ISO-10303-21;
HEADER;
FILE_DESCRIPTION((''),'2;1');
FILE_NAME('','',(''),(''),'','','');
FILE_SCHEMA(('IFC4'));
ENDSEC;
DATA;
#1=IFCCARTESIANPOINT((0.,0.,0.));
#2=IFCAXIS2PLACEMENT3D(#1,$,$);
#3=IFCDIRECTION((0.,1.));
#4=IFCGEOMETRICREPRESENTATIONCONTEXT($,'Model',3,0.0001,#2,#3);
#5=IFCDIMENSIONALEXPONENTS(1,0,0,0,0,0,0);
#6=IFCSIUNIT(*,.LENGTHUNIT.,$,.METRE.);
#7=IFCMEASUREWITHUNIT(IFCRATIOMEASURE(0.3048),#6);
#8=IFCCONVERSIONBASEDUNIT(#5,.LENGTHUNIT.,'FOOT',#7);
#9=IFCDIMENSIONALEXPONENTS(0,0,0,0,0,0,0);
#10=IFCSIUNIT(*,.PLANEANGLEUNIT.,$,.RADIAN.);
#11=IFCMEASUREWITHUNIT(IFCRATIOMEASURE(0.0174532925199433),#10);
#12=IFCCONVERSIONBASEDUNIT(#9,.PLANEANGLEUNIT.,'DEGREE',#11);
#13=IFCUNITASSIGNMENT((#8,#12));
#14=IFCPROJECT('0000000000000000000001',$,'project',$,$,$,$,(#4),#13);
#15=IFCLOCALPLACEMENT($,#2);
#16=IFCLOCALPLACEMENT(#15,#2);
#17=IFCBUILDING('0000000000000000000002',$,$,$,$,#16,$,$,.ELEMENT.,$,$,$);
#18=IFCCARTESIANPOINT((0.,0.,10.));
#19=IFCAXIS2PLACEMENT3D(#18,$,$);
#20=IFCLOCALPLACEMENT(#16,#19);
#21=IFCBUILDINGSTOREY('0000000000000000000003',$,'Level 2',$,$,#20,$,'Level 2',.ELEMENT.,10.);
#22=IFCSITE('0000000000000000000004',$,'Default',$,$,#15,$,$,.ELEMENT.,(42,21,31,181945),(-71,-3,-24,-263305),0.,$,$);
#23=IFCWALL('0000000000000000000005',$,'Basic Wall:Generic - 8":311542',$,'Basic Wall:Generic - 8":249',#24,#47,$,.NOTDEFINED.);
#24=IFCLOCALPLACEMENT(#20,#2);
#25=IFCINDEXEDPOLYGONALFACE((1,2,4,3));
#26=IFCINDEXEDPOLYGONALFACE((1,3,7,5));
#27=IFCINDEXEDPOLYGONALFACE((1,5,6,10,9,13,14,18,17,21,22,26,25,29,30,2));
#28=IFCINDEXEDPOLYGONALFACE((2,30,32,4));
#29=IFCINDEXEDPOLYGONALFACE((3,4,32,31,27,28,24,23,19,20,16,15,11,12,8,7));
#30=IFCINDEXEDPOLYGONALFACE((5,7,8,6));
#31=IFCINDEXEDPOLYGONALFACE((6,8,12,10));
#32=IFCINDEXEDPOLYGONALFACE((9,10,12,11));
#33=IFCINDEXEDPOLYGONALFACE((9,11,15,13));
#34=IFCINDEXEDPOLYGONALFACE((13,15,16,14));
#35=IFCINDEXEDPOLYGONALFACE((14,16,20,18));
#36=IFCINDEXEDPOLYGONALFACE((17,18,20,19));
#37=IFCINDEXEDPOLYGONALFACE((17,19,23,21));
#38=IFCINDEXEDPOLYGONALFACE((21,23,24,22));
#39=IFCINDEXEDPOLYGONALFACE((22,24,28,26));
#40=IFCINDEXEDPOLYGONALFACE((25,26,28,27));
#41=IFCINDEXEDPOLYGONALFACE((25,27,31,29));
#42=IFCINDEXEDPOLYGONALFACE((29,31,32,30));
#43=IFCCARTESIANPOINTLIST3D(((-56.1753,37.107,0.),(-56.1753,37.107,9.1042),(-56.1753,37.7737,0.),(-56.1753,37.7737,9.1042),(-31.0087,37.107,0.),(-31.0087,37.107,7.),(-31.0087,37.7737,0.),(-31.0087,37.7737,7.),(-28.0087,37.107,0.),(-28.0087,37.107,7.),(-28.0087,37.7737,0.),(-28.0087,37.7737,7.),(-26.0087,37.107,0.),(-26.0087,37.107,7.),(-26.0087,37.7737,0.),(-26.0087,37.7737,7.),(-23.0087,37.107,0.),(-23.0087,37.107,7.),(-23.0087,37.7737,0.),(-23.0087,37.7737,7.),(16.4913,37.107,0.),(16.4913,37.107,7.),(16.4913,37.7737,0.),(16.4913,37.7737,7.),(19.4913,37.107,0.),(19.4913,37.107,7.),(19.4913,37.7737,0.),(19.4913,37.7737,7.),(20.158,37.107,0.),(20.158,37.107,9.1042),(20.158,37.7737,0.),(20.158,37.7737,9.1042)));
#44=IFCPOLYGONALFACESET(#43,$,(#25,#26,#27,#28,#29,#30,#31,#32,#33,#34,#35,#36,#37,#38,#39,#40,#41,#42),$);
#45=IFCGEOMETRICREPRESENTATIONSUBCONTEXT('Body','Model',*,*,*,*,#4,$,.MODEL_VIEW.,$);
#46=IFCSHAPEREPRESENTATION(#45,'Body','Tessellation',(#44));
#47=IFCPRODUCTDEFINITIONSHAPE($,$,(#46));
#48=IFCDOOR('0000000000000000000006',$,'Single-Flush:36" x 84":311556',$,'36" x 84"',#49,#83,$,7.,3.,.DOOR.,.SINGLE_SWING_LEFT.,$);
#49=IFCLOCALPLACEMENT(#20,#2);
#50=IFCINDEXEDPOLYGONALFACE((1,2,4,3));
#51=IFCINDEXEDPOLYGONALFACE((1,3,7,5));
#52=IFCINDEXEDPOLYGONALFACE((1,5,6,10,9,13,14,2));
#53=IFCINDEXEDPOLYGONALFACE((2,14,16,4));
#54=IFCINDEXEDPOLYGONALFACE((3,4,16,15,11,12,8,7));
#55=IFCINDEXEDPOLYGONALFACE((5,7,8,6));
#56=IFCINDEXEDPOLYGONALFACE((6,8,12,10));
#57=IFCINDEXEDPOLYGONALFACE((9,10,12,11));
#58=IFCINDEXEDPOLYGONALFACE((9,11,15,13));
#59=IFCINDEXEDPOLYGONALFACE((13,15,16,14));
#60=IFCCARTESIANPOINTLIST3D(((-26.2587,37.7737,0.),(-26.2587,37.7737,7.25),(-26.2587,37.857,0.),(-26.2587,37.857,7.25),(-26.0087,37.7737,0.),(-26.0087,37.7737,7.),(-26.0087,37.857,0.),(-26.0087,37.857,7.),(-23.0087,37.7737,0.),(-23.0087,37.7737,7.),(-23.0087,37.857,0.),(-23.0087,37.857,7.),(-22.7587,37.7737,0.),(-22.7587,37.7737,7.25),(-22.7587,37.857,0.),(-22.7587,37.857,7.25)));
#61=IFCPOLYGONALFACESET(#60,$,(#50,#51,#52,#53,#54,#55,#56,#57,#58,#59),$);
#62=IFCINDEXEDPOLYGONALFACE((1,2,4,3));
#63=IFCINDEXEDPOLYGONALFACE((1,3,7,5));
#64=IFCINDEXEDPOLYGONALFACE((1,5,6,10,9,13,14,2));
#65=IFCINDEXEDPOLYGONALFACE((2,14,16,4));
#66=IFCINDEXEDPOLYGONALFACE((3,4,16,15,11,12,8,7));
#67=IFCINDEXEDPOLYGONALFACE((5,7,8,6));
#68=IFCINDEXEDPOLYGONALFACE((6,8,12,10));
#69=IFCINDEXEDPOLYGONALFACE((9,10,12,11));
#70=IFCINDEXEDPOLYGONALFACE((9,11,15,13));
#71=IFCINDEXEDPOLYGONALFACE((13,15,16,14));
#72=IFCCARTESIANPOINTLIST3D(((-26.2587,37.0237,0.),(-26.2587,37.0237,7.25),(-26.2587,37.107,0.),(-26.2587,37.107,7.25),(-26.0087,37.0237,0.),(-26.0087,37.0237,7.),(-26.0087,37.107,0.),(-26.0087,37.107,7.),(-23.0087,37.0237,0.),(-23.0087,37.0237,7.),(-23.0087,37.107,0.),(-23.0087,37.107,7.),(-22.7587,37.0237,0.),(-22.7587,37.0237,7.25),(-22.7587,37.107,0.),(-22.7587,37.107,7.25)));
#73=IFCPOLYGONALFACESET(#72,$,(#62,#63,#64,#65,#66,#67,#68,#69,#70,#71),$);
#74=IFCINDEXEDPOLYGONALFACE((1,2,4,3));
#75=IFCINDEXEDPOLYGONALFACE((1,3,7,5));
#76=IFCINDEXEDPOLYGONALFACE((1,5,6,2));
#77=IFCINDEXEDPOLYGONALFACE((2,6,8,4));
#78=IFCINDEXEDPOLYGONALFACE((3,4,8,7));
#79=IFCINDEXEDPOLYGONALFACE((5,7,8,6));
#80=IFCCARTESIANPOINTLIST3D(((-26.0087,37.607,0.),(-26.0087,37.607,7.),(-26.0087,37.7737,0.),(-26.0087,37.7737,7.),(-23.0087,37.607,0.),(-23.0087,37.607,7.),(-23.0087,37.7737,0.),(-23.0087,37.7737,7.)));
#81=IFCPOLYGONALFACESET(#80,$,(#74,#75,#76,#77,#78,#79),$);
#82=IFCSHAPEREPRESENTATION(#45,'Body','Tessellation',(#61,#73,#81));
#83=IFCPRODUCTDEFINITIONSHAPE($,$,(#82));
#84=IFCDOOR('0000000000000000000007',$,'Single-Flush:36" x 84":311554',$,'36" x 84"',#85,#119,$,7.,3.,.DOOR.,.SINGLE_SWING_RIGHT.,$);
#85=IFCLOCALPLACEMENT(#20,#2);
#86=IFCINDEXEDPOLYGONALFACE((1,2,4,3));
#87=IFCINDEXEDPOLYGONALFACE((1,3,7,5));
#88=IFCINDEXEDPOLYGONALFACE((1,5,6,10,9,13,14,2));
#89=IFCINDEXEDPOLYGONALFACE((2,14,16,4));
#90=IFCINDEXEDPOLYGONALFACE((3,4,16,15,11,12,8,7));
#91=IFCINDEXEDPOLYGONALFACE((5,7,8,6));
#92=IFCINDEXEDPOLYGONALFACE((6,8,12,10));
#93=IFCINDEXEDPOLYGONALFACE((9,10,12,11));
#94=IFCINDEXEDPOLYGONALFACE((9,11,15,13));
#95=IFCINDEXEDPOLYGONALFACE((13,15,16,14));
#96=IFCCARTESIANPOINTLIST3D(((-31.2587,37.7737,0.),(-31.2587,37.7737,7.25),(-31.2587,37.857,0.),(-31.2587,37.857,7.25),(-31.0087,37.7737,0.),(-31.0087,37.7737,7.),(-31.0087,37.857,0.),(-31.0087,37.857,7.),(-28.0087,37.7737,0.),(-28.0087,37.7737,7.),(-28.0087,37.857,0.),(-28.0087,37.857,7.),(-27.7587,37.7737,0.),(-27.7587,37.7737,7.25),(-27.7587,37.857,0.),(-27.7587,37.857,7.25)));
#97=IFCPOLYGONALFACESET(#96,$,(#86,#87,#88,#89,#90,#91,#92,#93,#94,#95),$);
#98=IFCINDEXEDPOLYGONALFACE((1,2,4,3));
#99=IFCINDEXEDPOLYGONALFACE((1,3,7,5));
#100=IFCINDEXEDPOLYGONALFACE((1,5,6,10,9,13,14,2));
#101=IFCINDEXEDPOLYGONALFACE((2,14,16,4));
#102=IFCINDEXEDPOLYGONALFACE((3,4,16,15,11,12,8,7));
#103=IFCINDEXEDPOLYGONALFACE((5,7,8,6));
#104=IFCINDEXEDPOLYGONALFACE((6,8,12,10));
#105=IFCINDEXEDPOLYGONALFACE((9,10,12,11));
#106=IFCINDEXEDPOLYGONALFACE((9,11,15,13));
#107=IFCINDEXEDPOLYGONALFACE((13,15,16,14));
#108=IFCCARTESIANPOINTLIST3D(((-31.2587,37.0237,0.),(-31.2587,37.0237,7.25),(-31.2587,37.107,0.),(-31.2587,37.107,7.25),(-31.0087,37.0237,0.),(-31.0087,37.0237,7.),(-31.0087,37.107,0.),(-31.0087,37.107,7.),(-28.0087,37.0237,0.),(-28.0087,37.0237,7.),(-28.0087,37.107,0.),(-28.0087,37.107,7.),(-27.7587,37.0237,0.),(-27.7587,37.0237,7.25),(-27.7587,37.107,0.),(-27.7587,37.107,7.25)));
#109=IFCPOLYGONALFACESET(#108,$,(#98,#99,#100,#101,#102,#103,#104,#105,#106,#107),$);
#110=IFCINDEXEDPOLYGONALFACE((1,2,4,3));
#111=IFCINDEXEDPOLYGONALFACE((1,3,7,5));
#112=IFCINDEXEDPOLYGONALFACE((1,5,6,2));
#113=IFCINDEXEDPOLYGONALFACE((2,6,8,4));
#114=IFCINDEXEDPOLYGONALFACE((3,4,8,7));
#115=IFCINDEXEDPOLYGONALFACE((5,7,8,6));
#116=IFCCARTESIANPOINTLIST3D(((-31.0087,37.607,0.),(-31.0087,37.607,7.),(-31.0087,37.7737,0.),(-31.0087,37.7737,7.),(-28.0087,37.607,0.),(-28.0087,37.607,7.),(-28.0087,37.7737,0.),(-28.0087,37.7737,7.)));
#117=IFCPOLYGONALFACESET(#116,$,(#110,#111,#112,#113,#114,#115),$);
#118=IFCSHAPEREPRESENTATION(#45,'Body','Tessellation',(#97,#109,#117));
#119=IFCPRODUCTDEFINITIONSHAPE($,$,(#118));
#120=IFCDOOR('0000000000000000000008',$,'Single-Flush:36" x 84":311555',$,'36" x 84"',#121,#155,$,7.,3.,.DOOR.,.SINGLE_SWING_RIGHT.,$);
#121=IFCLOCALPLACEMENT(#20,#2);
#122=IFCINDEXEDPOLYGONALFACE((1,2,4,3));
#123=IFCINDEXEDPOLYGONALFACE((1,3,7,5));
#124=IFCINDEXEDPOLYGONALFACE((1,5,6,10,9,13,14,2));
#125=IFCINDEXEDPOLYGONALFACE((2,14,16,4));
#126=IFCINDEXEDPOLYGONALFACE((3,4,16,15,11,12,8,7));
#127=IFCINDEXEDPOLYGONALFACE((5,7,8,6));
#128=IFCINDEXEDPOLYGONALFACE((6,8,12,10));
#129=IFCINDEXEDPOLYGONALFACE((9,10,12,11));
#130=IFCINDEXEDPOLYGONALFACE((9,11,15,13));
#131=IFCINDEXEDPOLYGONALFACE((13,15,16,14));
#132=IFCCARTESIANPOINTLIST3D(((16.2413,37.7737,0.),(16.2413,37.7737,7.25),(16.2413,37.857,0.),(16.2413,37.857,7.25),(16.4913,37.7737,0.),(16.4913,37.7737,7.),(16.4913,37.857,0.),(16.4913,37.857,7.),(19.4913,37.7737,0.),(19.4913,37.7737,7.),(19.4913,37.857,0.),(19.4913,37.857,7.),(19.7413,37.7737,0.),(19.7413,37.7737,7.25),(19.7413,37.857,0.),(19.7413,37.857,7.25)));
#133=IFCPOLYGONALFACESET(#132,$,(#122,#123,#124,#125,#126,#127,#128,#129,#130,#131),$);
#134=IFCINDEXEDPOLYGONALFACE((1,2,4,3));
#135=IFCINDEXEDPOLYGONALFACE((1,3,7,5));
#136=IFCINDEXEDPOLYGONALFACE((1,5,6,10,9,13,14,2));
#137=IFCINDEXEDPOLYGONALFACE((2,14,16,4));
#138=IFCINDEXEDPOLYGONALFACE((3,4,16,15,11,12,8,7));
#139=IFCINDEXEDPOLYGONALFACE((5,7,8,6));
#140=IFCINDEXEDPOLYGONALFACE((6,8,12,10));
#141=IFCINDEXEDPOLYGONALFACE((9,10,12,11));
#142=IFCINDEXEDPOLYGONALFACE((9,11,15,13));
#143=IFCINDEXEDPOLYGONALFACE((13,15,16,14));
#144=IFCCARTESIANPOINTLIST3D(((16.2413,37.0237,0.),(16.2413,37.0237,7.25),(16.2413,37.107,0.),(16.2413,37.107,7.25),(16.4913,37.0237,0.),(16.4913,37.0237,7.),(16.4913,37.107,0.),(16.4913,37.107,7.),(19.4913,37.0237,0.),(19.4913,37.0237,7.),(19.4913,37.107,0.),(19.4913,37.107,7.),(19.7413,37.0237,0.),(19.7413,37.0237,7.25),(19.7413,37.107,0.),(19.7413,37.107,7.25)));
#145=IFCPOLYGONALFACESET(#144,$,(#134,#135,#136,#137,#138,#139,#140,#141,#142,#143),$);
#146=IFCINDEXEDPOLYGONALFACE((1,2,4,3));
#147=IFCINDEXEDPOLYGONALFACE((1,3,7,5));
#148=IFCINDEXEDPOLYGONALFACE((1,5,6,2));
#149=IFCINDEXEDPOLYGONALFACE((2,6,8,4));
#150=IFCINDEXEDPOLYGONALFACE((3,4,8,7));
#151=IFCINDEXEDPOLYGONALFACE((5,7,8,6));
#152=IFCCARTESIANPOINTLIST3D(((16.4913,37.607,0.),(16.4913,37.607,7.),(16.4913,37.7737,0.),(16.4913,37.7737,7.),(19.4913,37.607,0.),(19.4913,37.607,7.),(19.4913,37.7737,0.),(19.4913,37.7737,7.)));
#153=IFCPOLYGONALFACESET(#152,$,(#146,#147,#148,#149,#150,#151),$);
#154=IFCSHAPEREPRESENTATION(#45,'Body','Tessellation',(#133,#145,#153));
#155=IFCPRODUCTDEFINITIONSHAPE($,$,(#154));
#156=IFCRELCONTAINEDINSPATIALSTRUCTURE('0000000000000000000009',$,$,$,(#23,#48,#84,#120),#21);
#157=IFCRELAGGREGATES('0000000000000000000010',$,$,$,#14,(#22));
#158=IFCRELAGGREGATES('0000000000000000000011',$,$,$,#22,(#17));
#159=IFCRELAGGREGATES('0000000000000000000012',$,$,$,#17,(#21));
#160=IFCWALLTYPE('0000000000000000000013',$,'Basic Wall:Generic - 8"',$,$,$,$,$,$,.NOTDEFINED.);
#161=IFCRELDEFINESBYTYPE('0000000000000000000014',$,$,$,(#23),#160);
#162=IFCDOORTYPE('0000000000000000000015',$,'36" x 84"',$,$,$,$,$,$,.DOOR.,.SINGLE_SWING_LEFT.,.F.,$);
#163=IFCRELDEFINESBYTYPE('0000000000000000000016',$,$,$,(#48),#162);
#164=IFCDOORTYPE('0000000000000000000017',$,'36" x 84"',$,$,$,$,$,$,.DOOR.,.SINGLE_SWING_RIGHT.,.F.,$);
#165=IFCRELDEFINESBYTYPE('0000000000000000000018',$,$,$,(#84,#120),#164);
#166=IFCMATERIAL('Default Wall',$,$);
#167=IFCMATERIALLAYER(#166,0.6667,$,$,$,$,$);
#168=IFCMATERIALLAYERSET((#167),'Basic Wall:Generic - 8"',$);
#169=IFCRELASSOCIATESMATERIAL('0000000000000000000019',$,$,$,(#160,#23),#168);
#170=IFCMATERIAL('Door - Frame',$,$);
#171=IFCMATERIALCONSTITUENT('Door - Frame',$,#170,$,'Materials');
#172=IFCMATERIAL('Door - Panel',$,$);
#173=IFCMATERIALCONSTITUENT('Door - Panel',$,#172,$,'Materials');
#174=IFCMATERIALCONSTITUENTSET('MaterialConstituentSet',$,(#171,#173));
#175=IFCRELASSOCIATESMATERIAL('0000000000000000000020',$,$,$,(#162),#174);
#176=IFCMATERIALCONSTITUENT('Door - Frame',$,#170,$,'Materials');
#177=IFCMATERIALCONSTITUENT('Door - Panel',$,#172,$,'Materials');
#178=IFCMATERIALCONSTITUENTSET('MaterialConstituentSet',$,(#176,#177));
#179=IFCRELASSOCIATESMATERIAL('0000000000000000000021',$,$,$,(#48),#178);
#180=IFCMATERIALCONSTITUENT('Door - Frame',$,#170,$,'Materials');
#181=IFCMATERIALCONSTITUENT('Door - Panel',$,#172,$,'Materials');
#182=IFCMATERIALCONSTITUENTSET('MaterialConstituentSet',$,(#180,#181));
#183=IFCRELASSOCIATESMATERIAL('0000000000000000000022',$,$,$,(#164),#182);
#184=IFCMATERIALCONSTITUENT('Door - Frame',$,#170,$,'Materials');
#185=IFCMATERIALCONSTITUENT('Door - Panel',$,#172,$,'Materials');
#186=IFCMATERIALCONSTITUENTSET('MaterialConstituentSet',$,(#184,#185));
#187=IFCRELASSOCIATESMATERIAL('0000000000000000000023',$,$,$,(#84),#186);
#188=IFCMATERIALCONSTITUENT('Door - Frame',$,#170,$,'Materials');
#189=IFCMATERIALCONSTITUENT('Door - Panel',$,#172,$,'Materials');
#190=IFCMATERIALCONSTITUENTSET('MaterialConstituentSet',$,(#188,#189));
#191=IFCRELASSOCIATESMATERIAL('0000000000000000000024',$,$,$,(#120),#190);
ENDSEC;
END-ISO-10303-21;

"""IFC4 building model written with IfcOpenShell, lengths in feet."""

from ifc_helpers import new_model, entity, si_unit, converted_unit, direction, frame, frame_2d, origin, place, context, subcontext, project, spatial, polyline, rectangle, outline, extrude, clip, bounded_halfspace, source, transform, mapped, material, layer, layer_set, layer_usage, constituent, constituent_set, type_object, type_shapes, element, fill, save


model = new_model("IFC4")

# Units and contexts
model_context = context("Model", 3, precision=0.0001, world=origin(), true_north=direction((0.0, 1.0)))
body_context = subcontext(model_context, "Body", "Model", "MODEL_VIEW")
ifc_project = project(units=[converted_unit("LENGTHUNIT", "FOOT", entity("IfcRatioMeasure", 0.3048), si_unit("LENGTHUNIT", "METRE"), dimensions=[1, 0, 0, 0, 0, 0, 0]), converted_unit("PLANEANGLEUNIT", "DEGREE", entity("IfcRatioMeasure", 0.0174532925199433), si_unit("PLANEANGLEUNIT", "RADIAN"), dimensions=[0, 0, 0, 0, 0, 0, 0])], contexts=[model_context])

# Site, building, storey
site_placement = place(None, origin())
site = spatial("IfcSite", under=ifc_project, at=site_placement, Name="Default", CompositionType="ELEMENT", RefLatitude=(42, 21, 31, 181945), RefLongitude=(-71, -3, -24, -263305), RefElevation=0.0)
building_placement = place(site_placement, origin())
building = spatial("IfcBuilding", under=site, at=building_placement, CompositionType="ELEMENT")
storey_placement = place(building_placement, frame((0.0, 0.0, 10.0)))
storey = spatial("IfcBuildingStorey", under=building, at=storey_placement, Name="Level 2", LongName="Level 2", CompositionType="ELEMENT", Elevation=10.0)

# Shared definitions
ifc_material_1 = material(Name="Default Wall")
ifc_layer = layer(ifc_material_1, 0.6667)
ifc_layer_set = layer_set([ifc_layer], Name="Basic Wall:Generic - 8\"")
wall_type = type_object("IfcWallType", Name="Basic Wall:Generic - 8\"", PredefinedType="NOTDEFINED", material=ifc_layer_set)

# Wall, openings, doors
ifc_layer_usage_1 = layer_usage(ifc_layer_set, "AXIS2", "NEGATIVE", 0.3333)
wall_1_placement = place(storey_placement, frame((-56.1753, 37.4404, 0.0)))
wall_1 = element("IfcWall", 1, at=wall_1_placement, inside=storey, type_object=wall_type, material=ifc_layer_usage_1, Name="Basic Wall:Generic - 8\":311542", ObjectType="Basic Wall:Generic - 8\":249", PredefinedType="NOTDEFINED", context=body_context, shape_type="Clipping", body=[
    clip(extrude(rectangle(XDim=76.3333, YDim=0.6667, at=frame_2d((38.1667, 0.0), x_axis=(-1.0, 0.0))), origin(), (0.0, 0.0, 1.0), 9.1042), bounded_halfspace(frame((0.0, -0.3333, 9.1042), z_axis=(0.0, 0.0, -1.0), x_axis=(0.0, -1.0, 0.0)), True, frame((0.0, -0.3333, 9.1042), z_axis=(0.0, 0.0, -1.0), x_axis=(0.0, -1.0, 0.0)), polyline([(0.0, 0.0), (-0.6667, 0.0), (-0.6667, -28.8333), (-0.6667, -29.5), (-0.6667, -51.8333), (-0.6667, -52.5), (-0.6667, -76.3333), (0.0, -76.3333), (0.0, -20.5), (0.0, -19.8333), (0.0, 0.0)]))),
])
opening_1_placement = place(wall_1_placement, frame((25.1667, -0.3333, 0.0)))
opening_1 = element("IfcOpeningElement", 2, at=opening_1_placement, cuts=wall_1, ObjectType="Opening", PredefinedType="OPENING", context=body_context, shape_type="SweptSolid", body=[
    extrude(rectangle(XDim=3.0, YDim=7.0, at=frame_2d((3.5, 1.5), x_axis=(0.0, 1.0))), frame((0.0, 0.0, 0.0), z_axis=(0.0, 1.0, 0.0), x_axis=(0.0, 0.0, 1.0)), (0.0, 0.0, 1.0), 0.6667),
])
opening_2_placement = place(wall_1_placement, frame((72.6667, -0.3333, 0.0)))
opening_2 = element("IfcOpeningElement", 3, at=opening_2_placement, cuts=wall_1, ObjectType="Opening", PredefinedType="OPENING", context=body_context, shape_type="SweptSolid", body=[
    extrude(rectangle(XDim=3.0, YDim=7.0, at=frame_2d((3.5, 1.5), x_axis=(0.0, 1.0))), frame((0.0, 0.0, 0.0), z_axis=(0.0, 1.0, 0.0), x_axis=(0.0, 0.0, 1.0)), (0.0, 0.0, 1.0), 0.6667),
])
opening_3_placement = place(wall_1_placement, frame((30.1667, -0.3333, 0.0)))
opening_3 = element("IfcOpeningElement", 4, at=opening_3_placement, cuts=wall_1, ObjectType="Opening", PredefinedType="OPENING", context=body_context, shape_type="SweptSolid", body=[
    extrude(rectangle(XDim=3.0, YDim=7.0, at=frame_2d((3.5, 1.5), x_axis=(0.0, -1.0))), frame((0.0, 0.0, 0.0), z_axis=(0.0, 1.0, 0.0), x_axis=(0.0, 0.0, 1.0)), (0.0, 0.0, 1.0), 0.6667),
])
ifc_material_2 = material(Name="Door - Frame")
ifc_constituent_1 = constituent(ifc_material_2, Name="Door - Frame", Category="Materials")
ifc_material_3 = material(Name="Door - Panel")
ifc_constituent_2 = constituent(ifc_material_3, Name="Door - Panel", Category="Materials")
ifc_constituent_set_1 = constituent_set(constituents=[ifc_constituent_1, ifc_constituent_2], Name="MaterialConstituentSet")
ifc_constituent_3 = constituent(ifc_material_2, Name="Door - Frame", Category="Materials")
ifc_constituent_4 = constituent(ifc_material_3, Name="Door - Panel", Category="Materials")
ifc_constituent_set_2 = constituent_set(constituents=[ifc_constituent_3, ifc_constituent_4], Name="MaterialConstituentSet")
door_type_1 = type_object("IfcDoorType", Name="36\" x 84\"", OperationType="SINGLE_SWING_LEFT", ParameterTakesPrecedence=False, PredefinedType="DOOR", material=ifc_constituent_set_2)
shared_shape_1 = source(origin(), body_context, "Body", "SweptSolid", [
    extrude(outline(polyline([(-1.75, -3.6875), (1.75, -3.6875), (1.75, 3.5625), (1.5, 3.5625), (1.5, -3.4375), (-1.5, -3.4375), (-1.5, 3.5625), (-1.75, 3.5625), (-1.75, -3.6875)])), frame((1.5, 0.75, 3.5625), z_axis=(0.0, -1.0, 0.0), x_axis=(-1.0, 0.0, 0.0)), (0.0, 0.0, 1.0), 0.0833),
    extrude(outline(polyline([(-3.6875, -1.75), (3.5625, -1.75), (3.5625, -1.5), (-3.4375, -1.5), (-3.4375, 1.5), (3.5625, 1.5), (3.5625, 1.75), (-3.6875, 1.75), (-3.6875, -1.75)])), frame((1.5, 0.0, 3.5625), z_axis=(0.0, -1.0, 0.0), x_axis=(0.0, 0.0, -1.0)), (0.0, 0.0, 1.0), 0.0833),
    extrude(rectangle(XDim=3.0, YDim=0.1667, at=frame_2d((0.0, 0.0), x_axis=(1.0, 0.0))), frame((1.5, 0.5833, 0.0)), (0.0, 0.0, 1.0), 7.0),
])
type_shapes(door_type_1, [shared_shape_1])
door_1_placement = place(opening_3_placement, origin())
door_1 = element("IfcDoor", 5, at=door_1_placement, inside=storey, type_object=door_type_1, material=ifc_constituent_set_1, Name="Single-Flush:36\" x 84\":311556", ObjectType="36\" x 84\"", OperationType="SINGLE_SWING_LEFT", OverallHeight=7.0, OverallWidth=3.0, PredefinedType="DOOR", context=body_context, shape_type="MappedRepresentation", body=[
    mapped(shared_shape_1, transform((0.0, 0.0, 0.0), scale=1.0)),
])
fill(opening_3, door_1)
ifc_constituent_5 = constituent(ifc_material_2, Name="Door - Frame", Category="Materials")
ifc_constituent_6 = constituent(ifc_material_3, Name="Door - Panel", Category="Materials")
ifc_constituent_set_3 = constituent_set(constituents=[ifc_constituent_5, ifc_constituent_6], Name="MaterialConstituentSet")
ifc_constituent_7 = constituent(ifc_material_2, Name="Door - Frame", Category="Materials")
ifc_constituent_8 = constituent(ifc_material_3, Name="Door - Panel", Category="Materials")
ifc_constituent_set_4 = constituent_set(constituents=[ifc_constituent_7, ifc_constituent_8], Name="MaterialConstituentSet")
door_type_2 = type_object("IfcDoorType", Name="36\" x 84\"", OperationType="SINGLE_SWING_RIGHT", ParameterTakesPrecedence=False, PredefinedType="DOOR", material=ifc_constituent_set_4)
shared_shape_2 = source(origin(), body_context, "Body", "SweptSolid", [
    extrude(outline(polyline([(-1.75, -3.6875), (1.75, -3.6875), (1.75, 3.5625), (1.5, 3.5625), (1.5, -3.4375), (-1.5, -3.4375), (-1.5, 3.5625), (-1.75, 3.5625), (-1.75, -3.6875)])), frame((1.5, 0.6667, 3.5625), z_axis=(0.0, 1.0, 0.0), x_axis=(1.0, 0.0, 0.0)), (0.0, 0.0, 1.0), 0.0833),
    extrude(outline(polyline([(-3.6875, -1.75), (3.5625, -1.75), (3.5625, -1.5), (-3.4375, -1.5), (-3.4375, 1.5), (3.5625, 1.5), (3.5625, 1.75), (-3.6875, 1.75), (-3.6875, -1.75)])), frame((1.5, -0.0833, 3.5625), z_axis=(0.0, 1.0, 0.0), x_axis=(0.0, 0.0, -1.0)), (0.0, 0.0, 1.0), 0.0833),
    extrude(rectangle(XDim=0.1667, YDim=3.0, at=frame_2d((0.0, 0.0), x_axis=(1.0, 0.0))), frame((1.5, 0.5833, 0.0), z_axis=(0.0, 0.0, 1.0), x_axis=(0.0, 1.0, 0.0)), (0.0, 0.0, 1.0), 7.0),
])
type_shapes(door_type_2, [shared_shape_2])
door_2_placement = place(opening_1_placement, origin())
door_2 = element("IfcDoor", 6, at=door_2_placement, inside=storey, type_object=door_type_2, material=ifc_constituent_set_3, Name="Single-Flush:36\" x 84\":311554", ObjectType="36\" x 84\"", OperationType="SINGLE_SWING_RIGHT", OverallHeight=7.0, OverallWidth=3.0, PredefinedType="DOOR", context=body_context, shape_type="MappedRepresentation", body=[
    mapped(shared_shape_2, transform((0.0, 0.0, 0.0), scale=1.0)),
])
fill(opening_1, door_2)
ifc_constituent_9 = constituent(ifc_material_2, Name="Door - Frame", Category="Materials")
ifc_constituent_10 = constituent(ifc_material_3, Name="Door - Panel", Category="Materials")
ifc_constituent_set_5 = constituent_set(constituents=[ifc_constituent_9, ifc_constituent_10], Name="MaterialConstituentSet")
door_3_placement = place(opening_2_placement, origin())
door_3 = element("IfcDoor", 7, at=door_3_placement, inside=storey, type_object=door_type_2, material=ifc_constituent_set_5, Name="Single-Flush:36\" x 84\":311555", ObjectType="36\" x 84\"", OperationType="SINGLE_SWING_RIGHT", OverallHeight=7.0, OverallWidth=3.0, PredefinedType="DOOR", context=body_context, shape_type="MappedRepresentation", body=[
    mapped(shared_shape_2, transform((0.0, 0.0, 0.0), scale=1.0)),
])
fill(opening_2, door_3)

save(model, "model.ifc")
